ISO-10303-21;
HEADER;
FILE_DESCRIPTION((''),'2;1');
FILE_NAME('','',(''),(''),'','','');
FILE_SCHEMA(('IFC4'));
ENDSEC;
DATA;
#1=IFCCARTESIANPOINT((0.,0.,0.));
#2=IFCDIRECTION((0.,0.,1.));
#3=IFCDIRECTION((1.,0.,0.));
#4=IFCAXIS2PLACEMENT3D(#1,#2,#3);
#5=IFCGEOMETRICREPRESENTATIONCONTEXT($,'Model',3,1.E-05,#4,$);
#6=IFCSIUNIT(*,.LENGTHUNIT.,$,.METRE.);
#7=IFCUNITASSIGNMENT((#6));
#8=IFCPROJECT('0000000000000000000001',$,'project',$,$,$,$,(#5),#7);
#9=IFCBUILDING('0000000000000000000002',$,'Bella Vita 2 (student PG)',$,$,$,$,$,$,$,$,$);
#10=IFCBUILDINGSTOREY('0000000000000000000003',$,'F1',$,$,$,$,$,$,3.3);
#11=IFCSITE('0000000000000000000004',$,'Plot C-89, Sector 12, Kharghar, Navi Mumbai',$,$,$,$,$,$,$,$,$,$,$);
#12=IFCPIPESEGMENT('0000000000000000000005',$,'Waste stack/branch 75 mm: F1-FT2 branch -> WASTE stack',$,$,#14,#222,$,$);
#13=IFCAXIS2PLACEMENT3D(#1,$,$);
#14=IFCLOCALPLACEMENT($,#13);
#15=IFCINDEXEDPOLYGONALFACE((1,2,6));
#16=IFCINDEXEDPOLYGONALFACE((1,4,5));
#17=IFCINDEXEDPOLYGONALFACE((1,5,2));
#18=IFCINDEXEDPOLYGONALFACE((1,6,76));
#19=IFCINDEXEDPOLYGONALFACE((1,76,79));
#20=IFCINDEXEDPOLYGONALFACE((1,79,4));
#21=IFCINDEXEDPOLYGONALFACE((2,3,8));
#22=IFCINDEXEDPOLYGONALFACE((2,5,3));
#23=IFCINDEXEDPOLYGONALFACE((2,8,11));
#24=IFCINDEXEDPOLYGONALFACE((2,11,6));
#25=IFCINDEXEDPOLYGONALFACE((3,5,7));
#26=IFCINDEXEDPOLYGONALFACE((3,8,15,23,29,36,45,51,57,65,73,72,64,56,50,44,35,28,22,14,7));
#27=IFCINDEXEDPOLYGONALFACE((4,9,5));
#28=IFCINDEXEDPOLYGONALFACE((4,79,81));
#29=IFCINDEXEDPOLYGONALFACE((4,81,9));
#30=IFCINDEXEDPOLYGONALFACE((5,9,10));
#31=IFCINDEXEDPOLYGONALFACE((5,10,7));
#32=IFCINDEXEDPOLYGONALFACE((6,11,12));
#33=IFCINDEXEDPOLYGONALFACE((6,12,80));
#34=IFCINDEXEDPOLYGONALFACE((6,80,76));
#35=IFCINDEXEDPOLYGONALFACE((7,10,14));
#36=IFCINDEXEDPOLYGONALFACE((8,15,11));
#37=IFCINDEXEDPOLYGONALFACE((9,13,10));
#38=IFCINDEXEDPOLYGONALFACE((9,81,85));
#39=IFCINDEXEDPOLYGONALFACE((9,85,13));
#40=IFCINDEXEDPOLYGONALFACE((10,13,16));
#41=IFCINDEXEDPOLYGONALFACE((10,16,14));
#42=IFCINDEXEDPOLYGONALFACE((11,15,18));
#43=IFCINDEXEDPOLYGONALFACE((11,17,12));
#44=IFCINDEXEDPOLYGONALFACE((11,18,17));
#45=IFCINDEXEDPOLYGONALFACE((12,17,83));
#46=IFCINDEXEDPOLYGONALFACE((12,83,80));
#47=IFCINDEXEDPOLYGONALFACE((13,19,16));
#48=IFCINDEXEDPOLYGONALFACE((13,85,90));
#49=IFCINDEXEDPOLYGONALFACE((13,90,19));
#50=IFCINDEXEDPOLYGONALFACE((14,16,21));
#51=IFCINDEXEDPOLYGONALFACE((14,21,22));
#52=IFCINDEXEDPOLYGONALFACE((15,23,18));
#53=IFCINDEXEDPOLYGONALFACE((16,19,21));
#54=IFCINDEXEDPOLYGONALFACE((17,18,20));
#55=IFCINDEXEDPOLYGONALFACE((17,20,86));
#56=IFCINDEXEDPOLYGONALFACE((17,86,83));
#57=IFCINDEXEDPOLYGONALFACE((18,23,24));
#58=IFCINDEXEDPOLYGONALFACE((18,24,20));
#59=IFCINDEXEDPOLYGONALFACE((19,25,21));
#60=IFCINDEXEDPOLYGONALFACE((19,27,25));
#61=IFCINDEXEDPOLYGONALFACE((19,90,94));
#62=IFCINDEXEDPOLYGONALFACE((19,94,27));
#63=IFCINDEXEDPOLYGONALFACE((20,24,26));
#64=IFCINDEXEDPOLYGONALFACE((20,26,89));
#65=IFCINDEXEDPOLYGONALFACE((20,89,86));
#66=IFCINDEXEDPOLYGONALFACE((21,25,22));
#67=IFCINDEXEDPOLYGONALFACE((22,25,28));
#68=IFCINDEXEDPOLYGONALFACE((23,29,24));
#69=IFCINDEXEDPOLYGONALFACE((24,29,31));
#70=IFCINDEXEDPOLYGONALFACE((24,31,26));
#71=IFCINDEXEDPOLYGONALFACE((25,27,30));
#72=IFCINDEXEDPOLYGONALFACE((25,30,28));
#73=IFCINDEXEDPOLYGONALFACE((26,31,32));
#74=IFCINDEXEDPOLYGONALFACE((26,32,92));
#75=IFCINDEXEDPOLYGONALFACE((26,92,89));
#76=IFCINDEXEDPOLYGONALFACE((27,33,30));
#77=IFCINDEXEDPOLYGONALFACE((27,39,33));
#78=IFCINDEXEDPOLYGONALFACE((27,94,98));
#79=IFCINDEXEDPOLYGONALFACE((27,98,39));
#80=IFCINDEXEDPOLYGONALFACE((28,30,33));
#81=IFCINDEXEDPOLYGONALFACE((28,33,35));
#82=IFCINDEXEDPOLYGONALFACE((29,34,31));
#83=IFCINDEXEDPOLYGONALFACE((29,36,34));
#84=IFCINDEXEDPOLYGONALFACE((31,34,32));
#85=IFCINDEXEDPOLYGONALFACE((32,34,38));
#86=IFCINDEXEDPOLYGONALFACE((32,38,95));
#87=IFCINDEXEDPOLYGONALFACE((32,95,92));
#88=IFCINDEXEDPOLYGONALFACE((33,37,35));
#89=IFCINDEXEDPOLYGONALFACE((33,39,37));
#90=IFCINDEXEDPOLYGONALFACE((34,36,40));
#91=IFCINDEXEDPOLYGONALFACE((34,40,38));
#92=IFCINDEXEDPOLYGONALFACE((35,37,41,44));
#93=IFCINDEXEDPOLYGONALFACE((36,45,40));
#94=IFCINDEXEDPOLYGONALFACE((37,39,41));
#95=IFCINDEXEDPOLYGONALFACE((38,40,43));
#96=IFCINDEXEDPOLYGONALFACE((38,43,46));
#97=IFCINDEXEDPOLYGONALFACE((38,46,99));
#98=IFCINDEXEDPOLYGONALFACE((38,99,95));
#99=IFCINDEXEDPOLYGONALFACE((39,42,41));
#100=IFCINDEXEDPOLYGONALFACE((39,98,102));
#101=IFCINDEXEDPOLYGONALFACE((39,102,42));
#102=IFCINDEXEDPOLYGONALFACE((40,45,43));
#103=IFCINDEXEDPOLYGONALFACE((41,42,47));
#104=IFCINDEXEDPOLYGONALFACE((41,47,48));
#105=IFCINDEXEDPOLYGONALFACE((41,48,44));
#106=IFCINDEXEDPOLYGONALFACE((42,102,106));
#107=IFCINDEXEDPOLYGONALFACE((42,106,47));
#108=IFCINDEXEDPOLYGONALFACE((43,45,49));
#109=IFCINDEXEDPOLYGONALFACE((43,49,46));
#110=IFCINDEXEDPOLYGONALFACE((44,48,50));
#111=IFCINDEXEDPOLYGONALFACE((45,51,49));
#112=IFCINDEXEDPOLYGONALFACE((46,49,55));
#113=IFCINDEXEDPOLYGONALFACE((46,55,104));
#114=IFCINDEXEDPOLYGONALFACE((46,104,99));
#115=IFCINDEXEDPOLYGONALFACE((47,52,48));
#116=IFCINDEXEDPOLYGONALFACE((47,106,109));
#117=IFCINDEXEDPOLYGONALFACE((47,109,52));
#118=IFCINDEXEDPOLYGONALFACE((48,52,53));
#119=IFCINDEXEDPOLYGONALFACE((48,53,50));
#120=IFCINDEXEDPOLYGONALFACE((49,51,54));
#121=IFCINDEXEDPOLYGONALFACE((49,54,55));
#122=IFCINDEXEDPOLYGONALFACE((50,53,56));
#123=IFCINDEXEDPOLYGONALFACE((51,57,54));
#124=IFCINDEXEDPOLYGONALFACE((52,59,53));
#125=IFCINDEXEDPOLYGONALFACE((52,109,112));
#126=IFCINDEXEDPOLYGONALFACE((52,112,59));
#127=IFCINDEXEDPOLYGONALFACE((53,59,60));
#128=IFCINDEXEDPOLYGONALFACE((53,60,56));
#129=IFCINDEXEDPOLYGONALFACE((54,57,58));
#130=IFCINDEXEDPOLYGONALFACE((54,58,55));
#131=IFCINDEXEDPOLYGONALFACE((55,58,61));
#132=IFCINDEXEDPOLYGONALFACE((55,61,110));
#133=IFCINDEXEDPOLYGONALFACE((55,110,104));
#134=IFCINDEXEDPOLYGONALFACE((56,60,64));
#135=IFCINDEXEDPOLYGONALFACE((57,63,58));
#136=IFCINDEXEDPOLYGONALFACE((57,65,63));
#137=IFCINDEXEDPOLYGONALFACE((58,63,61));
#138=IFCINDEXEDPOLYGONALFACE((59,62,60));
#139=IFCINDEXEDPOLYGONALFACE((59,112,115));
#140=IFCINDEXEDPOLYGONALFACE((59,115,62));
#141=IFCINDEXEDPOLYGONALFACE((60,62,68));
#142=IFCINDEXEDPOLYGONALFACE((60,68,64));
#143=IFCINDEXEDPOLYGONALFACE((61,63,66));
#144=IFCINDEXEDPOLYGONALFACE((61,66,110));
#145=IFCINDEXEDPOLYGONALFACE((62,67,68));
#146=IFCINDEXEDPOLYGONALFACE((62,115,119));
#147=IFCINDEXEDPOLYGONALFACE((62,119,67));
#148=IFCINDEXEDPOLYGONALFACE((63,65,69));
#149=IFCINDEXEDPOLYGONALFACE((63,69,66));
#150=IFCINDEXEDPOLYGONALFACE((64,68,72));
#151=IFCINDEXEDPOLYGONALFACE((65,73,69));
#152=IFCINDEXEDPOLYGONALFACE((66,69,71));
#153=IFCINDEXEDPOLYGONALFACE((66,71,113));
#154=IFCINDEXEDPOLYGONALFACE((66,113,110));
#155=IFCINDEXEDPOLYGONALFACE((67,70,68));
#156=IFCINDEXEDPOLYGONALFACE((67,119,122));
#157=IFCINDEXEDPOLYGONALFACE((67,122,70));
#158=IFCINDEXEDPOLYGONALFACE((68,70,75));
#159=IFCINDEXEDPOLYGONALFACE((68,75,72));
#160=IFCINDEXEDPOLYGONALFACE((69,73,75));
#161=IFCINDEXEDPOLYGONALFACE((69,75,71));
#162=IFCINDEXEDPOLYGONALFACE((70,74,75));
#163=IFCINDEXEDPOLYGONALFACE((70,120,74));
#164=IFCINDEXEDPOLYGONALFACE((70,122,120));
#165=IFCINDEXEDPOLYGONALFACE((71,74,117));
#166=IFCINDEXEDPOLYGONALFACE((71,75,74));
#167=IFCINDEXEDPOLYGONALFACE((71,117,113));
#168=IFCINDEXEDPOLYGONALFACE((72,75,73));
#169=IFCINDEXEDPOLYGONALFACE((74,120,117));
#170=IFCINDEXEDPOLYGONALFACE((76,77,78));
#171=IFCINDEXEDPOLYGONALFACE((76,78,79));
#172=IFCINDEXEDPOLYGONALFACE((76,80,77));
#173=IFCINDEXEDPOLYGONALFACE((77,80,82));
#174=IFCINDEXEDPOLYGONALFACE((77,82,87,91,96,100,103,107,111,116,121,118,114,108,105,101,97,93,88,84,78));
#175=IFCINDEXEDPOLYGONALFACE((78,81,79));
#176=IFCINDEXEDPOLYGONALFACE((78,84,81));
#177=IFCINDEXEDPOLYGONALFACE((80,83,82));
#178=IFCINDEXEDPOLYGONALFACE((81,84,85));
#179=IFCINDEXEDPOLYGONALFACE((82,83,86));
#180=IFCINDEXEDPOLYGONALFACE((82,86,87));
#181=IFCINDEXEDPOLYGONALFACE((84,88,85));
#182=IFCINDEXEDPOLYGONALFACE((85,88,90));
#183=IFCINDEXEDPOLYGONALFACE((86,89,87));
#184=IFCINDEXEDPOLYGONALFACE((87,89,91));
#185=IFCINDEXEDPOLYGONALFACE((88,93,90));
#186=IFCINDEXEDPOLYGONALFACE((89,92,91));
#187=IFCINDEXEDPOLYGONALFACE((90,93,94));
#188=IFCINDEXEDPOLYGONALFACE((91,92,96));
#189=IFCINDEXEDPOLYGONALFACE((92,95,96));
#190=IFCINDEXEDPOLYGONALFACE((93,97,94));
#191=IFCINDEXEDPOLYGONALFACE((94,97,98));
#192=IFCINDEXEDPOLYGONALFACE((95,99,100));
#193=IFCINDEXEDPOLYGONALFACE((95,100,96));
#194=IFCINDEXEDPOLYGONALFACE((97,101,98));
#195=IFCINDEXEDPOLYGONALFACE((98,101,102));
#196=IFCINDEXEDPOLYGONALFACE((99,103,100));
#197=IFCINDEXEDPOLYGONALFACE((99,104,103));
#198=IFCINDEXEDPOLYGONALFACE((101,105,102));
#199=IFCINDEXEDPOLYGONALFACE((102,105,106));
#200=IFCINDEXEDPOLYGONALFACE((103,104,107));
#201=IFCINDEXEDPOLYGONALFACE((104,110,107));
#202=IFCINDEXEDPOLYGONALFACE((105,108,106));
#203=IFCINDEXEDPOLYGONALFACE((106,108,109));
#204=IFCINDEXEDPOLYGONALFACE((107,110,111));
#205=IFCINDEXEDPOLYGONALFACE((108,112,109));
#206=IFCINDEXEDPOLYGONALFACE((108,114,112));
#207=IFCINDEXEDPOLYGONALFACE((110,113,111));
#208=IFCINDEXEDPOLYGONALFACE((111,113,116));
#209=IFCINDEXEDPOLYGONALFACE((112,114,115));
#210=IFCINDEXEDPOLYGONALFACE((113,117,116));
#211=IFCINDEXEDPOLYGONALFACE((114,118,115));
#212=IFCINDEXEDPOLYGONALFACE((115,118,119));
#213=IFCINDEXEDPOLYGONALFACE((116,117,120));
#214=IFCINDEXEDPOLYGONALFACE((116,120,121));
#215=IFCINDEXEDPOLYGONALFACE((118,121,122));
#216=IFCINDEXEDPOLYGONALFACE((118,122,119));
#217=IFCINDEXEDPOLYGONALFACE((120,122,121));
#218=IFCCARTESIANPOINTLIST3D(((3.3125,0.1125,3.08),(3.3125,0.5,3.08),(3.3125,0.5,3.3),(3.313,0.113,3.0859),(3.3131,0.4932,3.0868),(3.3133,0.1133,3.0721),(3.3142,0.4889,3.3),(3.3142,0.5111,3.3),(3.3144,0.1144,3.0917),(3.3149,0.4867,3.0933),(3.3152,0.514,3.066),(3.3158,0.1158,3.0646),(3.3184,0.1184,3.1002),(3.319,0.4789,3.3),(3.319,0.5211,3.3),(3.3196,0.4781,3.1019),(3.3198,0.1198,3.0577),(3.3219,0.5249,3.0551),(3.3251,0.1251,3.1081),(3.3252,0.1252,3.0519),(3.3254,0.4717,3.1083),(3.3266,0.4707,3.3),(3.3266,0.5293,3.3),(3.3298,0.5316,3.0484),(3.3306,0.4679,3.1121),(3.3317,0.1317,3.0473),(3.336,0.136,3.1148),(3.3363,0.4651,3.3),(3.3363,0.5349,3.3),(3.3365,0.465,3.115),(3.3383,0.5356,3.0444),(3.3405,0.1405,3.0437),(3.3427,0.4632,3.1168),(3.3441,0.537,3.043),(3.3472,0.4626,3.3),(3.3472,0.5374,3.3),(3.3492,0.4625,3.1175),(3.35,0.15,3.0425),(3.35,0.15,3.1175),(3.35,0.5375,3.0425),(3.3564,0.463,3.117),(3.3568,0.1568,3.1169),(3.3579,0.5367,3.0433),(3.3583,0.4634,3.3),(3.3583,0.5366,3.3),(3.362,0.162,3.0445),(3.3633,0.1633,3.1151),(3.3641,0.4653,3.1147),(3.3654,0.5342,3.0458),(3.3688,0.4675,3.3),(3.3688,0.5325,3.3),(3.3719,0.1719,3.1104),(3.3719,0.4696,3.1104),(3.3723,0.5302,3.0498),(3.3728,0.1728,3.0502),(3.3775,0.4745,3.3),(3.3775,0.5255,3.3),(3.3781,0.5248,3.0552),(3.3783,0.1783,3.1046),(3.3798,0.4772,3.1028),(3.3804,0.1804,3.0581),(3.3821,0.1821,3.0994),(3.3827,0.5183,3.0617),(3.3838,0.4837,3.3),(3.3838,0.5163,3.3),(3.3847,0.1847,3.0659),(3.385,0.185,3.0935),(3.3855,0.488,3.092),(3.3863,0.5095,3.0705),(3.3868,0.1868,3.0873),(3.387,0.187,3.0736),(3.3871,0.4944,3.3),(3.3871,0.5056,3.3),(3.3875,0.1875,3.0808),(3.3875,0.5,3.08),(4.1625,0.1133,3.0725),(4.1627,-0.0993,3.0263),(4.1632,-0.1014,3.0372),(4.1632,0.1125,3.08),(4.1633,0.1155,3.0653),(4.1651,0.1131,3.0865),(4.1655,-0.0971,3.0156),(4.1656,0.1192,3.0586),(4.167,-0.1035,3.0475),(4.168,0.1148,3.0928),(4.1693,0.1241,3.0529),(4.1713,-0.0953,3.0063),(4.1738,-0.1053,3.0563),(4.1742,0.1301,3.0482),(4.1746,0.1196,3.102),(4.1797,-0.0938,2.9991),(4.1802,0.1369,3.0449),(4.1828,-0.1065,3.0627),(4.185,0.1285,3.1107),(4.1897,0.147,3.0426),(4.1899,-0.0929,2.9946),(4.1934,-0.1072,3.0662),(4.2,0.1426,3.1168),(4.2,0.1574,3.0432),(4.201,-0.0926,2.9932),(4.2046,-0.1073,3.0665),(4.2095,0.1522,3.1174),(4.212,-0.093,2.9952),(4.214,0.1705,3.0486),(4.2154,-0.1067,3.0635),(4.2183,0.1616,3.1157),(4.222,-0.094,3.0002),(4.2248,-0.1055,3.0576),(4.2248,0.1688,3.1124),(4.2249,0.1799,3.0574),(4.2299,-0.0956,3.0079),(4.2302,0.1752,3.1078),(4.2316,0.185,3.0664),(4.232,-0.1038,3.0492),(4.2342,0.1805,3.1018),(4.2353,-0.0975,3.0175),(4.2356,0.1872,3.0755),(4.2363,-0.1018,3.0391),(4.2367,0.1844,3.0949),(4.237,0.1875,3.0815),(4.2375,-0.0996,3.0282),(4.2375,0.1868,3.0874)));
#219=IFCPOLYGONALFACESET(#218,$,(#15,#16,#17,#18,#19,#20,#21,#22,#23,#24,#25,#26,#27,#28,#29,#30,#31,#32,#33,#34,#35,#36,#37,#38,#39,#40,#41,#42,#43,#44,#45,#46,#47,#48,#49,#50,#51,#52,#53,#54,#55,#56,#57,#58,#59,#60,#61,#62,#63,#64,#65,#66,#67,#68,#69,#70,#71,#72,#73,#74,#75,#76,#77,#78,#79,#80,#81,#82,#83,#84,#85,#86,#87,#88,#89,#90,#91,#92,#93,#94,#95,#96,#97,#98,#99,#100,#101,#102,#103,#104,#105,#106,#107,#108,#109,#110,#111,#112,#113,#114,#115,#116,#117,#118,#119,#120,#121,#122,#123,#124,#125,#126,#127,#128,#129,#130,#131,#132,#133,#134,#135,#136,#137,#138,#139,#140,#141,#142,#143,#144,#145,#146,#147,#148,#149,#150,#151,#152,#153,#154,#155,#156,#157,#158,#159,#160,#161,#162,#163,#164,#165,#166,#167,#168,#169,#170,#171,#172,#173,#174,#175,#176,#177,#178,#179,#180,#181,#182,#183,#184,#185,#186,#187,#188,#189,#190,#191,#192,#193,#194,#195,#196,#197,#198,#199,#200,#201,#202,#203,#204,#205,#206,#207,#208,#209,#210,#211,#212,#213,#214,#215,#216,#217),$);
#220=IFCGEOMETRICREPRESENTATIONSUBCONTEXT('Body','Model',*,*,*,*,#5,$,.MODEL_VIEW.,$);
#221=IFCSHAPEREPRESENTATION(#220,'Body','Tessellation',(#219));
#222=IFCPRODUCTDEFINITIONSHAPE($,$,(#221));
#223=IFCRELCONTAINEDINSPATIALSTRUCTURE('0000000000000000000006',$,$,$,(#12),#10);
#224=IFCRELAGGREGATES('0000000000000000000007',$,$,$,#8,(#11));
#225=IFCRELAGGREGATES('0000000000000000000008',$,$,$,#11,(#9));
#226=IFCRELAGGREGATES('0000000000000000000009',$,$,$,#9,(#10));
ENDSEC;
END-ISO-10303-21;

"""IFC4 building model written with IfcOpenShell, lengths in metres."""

from ifc_helpers import new_model, entity, si_unit, origin, origin_with_axes, place, context, subcontext, project, spatial, element, save


model = new_model("IFC4")

# Units and contexts
model_context = context("Model", 3, precision=1e-05, world=origin_with_axes())
body_context = subcontext(model_context, "Body", "Model", "MODEL_VIEW")
ifc_project = project(units=[si_unit("LENGTHUNIT", "METRE")], contexts=[model_context])

# Site, building, storey
site = spatial("IfcSite", under=ifc_project, Name="Plot C-89, Sector 12, Kharghar, Navi Mumbai")
building = spatial("IfcBuilding", under=site, Name="Bella Vita 2 (student PG)")
storey = spatial("IfcBuildingStorey", under=building, Name="F1", Elevation=3.3)

# Pipe segment
pipe_segment_1_placement = place(None, origin())
element("IfcPipeSegment", 1, at=pipe_segment_1_placement, inside=storey, Name="Waste stack/branch 75 mm: F1-FT2 branch -> WASTE stack", context=body_context, shape_type="AdvancedSweptSolid", body=[
    entity("IfcSweptDiskSolid", entity("IfcPolyline", [entity("IfcCartesianPoint", [3.35, 0.5, 3.3]), entity("IfcCartesianPoint", [3.35, 0.5, 3.08]), entity("IfcCartesianPoint", [3.35, 0.15, 3.08]), entity("IfcCartesianPoint", [4.2, 0.15, 3.08]), entity("IfcCartesianPoint", [4.2, -0.1, 3.03])]), 0.0375),
])

save(model, "model.ifc")
